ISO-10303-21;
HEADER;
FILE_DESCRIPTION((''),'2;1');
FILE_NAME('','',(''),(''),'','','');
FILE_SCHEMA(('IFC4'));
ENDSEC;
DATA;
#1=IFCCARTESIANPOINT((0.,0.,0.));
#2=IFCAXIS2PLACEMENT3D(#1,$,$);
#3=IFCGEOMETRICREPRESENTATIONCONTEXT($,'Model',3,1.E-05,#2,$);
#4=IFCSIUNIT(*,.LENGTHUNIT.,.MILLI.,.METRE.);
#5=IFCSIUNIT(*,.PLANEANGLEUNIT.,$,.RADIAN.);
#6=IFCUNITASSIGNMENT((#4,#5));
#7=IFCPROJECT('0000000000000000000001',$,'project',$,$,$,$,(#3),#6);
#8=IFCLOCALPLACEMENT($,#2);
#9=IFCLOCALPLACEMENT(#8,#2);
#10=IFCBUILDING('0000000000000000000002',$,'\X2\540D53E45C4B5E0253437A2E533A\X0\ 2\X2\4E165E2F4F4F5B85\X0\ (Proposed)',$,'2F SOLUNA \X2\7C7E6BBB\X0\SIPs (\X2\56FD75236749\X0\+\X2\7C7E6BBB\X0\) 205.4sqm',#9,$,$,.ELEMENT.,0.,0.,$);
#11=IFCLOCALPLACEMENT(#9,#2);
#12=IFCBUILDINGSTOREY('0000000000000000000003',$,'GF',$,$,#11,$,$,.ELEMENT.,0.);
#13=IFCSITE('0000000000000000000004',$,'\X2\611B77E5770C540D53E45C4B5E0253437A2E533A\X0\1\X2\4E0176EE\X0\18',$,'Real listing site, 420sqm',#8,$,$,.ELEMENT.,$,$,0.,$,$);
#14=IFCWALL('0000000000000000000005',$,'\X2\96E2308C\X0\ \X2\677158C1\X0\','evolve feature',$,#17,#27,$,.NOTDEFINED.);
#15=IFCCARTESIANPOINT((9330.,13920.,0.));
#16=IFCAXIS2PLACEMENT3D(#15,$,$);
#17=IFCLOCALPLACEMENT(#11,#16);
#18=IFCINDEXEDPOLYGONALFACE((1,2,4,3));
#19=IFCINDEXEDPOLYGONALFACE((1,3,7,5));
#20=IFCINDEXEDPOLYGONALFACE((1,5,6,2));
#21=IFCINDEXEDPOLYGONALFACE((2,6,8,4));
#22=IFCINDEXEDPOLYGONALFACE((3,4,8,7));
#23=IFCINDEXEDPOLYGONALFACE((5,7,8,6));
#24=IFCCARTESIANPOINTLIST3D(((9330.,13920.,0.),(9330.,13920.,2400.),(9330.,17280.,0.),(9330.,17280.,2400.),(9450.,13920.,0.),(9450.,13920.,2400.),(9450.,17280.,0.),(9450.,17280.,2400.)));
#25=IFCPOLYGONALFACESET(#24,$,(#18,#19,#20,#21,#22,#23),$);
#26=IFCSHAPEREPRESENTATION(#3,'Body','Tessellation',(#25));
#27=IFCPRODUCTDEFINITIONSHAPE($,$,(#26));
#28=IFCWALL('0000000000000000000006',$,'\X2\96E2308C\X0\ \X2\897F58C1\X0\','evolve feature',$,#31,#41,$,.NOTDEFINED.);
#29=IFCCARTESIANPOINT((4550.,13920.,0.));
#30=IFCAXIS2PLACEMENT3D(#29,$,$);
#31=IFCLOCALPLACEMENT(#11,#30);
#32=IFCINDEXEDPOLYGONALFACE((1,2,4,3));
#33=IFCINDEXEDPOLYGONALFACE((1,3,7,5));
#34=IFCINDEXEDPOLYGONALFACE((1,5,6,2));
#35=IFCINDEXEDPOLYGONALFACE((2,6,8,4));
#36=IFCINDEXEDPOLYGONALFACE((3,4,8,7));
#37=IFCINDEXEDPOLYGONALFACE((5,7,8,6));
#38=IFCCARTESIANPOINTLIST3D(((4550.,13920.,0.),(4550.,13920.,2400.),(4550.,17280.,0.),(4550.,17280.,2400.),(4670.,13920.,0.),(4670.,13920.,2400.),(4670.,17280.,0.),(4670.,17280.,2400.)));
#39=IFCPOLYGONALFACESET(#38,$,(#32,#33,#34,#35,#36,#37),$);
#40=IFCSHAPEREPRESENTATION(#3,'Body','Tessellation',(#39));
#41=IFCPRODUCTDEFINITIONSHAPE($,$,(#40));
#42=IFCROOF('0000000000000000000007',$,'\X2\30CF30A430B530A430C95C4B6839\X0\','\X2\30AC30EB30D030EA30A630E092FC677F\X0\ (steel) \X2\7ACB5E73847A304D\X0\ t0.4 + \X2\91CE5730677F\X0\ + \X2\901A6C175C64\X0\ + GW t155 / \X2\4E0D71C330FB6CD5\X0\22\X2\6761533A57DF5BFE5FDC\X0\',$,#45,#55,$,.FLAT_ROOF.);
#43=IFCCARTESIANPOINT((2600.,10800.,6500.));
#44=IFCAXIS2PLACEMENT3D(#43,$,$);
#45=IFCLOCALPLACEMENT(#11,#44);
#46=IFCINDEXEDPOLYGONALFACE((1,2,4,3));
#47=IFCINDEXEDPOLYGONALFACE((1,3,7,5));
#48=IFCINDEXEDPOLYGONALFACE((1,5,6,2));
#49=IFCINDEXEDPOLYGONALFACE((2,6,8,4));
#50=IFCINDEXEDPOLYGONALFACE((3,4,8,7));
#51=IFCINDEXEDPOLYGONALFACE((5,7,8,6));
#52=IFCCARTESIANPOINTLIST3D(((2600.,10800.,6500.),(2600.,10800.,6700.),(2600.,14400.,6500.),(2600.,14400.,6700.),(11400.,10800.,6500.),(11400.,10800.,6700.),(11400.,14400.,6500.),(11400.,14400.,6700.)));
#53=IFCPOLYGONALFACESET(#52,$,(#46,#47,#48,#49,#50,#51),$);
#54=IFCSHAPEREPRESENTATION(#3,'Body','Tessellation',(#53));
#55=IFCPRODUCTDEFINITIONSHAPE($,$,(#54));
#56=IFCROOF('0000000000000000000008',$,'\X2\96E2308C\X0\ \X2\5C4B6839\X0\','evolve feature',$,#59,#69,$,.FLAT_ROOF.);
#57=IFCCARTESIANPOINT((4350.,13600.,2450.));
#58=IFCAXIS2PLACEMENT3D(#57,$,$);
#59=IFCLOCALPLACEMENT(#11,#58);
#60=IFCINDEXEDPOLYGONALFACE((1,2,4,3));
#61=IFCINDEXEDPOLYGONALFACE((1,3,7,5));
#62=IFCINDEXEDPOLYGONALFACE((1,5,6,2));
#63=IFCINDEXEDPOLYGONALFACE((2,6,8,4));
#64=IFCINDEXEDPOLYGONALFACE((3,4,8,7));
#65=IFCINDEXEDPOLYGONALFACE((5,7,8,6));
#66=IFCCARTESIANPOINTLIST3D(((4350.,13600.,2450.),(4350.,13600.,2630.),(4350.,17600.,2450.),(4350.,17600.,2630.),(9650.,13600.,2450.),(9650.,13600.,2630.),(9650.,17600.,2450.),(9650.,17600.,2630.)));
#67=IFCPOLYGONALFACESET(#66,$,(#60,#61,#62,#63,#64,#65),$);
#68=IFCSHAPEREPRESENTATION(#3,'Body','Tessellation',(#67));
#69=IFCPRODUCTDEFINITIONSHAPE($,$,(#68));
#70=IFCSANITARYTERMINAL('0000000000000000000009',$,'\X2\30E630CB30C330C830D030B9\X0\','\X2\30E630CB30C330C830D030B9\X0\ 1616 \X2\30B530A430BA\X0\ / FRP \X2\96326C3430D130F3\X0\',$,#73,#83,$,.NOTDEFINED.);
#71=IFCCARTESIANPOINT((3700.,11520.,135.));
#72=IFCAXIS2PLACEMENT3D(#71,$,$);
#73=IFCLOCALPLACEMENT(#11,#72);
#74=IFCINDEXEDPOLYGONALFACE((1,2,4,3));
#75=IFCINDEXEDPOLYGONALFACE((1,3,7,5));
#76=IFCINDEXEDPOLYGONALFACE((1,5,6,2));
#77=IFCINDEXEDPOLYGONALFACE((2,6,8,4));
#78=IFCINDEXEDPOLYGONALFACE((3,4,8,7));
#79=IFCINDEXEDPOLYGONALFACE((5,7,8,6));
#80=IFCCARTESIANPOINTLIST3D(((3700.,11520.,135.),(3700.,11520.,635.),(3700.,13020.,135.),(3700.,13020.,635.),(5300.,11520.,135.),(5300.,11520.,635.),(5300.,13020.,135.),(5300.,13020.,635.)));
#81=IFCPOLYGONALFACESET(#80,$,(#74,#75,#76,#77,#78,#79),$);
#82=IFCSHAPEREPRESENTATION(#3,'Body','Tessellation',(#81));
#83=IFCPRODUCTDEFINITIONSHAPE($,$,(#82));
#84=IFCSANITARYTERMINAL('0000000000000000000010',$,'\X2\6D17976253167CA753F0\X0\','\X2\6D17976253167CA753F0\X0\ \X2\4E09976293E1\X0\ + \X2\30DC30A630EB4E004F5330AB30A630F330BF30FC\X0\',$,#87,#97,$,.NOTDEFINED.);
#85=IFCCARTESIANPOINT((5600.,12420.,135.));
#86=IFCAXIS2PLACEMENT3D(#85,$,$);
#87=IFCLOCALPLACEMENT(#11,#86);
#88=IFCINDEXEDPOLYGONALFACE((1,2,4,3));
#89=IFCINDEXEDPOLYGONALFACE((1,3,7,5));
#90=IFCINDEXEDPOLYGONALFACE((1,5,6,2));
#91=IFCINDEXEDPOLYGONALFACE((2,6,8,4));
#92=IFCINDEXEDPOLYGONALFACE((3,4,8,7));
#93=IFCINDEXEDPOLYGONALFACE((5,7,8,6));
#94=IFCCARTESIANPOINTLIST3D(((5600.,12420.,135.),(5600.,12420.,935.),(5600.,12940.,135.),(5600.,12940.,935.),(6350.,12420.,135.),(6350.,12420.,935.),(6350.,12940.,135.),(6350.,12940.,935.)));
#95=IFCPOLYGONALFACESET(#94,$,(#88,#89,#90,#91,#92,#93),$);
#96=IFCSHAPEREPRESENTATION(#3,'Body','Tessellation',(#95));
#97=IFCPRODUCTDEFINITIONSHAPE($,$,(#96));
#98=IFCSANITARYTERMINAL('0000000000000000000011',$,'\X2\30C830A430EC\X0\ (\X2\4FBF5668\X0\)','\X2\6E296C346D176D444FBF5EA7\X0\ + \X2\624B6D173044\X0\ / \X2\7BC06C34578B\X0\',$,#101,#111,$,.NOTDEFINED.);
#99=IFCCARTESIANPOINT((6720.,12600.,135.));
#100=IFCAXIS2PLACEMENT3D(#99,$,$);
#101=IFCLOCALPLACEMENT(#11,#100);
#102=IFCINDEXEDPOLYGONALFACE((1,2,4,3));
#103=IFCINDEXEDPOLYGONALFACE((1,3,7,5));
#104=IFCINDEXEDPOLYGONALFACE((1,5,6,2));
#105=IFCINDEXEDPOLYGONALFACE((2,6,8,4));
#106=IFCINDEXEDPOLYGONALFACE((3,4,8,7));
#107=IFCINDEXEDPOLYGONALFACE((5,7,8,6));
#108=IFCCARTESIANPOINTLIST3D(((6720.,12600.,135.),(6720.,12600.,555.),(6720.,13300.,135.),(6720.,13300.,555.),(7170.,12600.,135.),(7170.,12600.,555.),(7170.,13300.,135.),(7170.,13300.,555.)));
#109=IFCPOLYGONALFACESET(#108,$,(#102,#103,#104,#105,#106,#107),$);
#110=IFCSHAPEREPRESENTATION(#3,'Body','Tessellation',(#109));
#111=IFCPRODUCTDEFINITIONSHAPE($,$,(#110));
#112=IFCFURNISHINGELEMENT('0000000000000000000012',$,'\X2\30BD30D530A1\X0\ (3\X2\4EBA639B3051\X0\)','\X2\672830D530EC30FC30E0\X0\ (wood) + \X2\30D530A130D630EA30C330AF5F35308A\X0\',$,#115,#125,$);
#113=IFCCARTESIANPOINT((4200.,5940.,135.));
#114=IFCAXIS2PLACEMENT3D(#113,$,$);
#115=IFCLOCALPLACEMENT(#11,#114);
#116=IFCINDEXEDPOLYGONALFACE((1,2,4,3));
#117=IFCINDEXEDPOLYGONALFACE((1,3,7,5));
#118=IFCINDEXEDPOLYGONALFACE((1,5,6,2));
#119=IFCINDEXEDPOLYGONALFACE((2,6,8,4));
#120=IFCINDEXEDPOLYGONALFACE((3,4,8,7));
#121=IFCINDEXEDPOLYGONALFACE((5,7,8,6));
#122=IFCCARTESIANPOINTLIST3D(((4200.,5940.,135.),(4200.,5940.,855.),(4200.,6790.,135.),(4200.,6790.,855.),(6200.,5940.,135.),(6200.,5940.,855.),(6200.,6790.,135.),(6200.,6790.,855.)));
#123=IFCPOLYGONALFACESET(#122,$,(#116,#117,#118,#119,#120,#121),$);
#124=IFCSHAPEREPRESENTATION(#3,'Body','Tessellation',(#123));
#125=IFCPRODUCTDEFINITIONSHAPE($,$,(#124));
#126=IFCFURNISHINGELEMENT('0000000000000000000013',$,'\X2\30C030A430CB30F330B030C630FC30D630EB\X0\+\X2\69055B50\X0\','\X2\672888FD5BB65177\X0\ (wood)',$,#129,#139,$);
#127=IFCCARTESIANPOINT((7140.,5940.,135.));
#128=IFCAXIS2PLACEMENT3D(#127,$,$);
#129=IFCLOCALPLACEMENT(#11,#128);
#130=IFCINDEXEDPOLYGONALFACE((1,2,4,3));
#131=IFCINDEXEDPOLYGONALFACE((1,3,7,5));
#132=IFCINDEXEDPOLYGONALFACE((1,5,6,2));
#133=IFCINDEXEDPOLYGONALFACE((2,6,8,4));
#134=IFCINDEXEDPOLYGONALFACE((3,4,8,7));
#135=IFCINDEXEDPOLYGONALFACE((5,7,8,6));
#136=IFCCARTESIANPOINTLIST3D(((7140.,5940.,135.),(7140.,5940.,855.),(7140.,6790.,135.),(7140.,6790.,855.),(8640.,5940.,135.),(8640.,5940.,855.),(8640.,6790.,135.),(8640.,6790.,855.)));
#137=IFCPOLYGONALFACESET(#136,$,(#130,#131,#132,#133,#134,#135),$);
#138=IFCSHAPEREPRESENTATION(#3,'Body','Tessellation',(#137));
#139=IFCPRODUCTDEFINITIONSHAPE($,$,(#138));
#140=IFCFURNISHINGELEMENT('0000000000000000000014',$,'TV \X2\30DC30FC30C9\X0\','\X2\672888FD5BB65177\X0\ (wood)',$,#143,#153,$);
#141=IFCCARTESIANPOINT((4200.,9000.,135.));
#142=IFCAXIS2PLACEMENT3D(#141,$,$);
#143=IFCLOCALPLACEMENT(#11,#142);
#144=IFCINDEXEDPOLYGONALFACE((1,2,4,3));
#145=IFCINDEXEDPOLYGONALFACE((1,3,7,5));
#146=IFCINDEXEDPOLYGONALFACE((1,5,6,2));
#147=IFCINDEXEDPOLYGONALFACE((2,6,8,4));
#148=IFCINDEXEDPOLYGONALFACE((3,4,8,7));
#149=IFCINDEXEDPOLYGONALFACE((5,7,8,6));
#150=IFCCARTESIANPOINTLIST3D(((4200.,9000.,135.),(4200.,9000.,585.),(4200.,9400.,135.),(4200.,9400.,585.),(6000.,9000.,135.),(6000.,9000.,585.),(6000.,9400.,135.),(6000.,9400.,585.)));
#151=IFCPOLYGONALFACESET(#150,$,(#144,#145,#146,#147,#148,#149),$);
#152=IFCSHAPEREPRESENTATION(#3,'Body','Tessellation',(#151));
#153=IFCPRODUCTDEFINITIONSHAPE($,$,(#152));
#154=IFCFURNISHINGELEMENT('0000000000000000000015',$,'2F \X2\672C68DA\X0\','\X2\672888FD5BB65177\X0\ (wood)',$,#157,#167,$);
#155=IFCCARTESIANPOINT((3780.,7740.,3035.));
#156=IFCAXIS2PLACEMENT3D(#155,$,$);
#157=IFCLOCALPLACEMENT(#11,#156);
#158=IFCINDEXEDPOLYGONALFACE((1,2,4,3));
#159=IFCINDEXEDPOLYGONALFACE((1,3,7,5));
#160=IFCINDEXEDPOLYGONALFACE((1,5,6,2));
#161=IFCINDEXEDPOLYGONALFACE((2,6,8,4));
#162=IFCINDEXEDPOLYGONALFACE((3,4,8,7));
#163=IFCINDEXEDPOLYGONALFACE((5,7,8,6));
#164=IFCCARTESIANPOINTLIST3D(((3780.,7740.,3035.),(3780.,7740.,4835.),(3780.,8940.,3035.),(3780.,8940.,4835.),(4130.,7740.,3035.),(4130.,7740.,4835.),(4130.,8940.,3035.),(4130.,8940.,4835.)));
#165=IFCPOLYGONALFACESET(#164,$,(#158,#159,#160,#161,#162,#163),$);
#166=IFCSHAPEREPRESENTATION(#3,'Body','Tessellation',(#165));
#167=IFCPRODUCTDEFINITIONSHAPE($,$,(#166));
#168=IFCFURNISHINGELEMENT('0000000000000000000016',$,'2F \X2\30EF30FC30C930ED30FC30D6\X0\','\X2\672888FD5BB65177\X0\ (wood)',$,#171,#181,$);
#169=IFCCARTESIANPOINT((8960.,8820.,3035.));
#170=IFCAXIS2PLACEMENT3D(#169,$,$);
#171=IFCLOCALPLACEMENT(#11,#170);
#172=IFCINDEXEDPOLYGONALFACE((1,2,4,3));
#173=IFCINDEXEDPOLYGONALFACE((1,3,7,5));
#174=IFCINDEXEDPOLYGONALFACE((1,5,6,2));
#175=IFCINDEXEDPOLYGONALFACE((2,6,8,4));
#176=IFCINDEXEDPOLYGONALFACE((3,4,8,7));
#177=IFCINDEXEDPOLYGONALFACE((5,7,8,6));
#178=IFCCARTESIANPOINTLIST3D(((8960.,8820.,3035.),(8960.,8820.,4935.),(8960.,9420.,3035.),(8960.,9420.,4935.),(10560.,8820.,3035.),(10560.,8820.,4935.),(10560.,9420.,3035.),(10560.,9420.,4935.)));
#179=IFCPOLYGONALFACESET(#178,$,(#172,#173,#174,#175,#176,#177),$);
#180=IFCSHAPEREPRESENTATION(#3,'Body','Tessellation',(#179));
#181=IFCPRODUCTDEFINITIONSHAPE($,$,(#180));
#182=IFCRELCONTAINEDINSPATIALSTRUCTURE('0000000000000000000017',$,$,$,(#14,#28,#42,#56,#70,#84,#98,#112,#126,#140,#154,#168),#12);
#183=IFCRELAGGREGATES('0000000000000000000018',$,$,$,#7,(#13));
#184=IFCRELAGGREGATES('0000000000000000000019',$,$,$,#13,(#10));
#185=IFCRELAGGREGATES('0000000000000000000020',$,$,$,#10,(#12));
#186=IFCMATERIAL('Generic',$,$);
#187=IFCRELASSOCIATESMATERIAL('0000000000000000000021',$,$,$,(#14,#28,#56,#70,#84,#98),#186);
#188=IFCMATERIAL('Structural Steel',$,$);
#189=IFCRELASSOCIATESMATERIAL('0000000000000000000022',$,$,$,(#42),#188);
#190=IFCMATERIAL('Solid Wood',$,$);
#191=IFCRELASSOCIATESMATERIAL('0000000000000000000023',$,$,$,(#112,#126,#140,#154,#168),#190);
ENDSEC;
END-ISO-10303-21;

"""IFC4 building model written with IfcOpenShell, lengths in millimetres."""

from ifc_helpers import new_model, si_unit, frame, frame_2d, origin, place, context, project, spatial, rectangle, extrude, material, element, save


model = new_model("IFC4")

# Units and contexts
model_context = context("Model", 3, precision=1e-05, world=origin())
ifc_project = project(units=[si_unit("LENGTHUNIT", "METRE", prefix="MILLI"), si_unit("PLANEANGLEUNIT", "RADIAN")], contexts=[model_context])

# Site, building, storey
site_placement = place(None, origin())
site = spatial("IfcSite", under=ifc_project, at=site_placement, Name="愛知県名古屋市千種区1丁目18", ObjectType="Real listing site, 420sqm", CompositionType="ELEMENT", RefElevation=0.0)
building_placement = place(site_placement, origin())
building = spatial("IfcBuilding", under=site, at=building_placement, Name="名古屋市千種区 2世帯住宅 (Proposed)", ObjectType="2F SOLUNA 籾殻SIPs (国産杉+籾殻) 205.4sqm", CompositionType="ELEMENT", ElevationOfRefHeight=0.0, ElevationOfTerrain=0.0)
storey_placement = place(building_placement, origin())
storey = spatial("IfcBuildingStorey", under=building, at=storey_placement, Name="GF", CompositionType="ELEMENT", Elevation=0.0)

# Shared definitions
ifc_material_1 = material(Name="Generic")

# Shared definitions
ifc_material_2 = material(Name="Solid Wood")

# Walls
wall_1_placement = place(storey_placement, frame((9330.0, 13920.0, 0.0)))
element("IfcWall", 1, at=wall_1_placement, inside=storey, material=ifc_material_1, Name="離れ 東壁", Description="evolve feature", PredefinedType="NOTDEFINED", context=model_context, shape_type="SweptSolid", body=[
    extrude(rectangle(XDim=120.0, YDim=3360.0, at=frame_2d((60.0, 1680.0))), frame((9330.0, 13920.0, 0.0)), (0.0, 0.0, 1.0), 2400.0),
])
wall_2_placement = place(storey_placement, frame((4550.0, 13920.0, 0.0)))
element("IfcWall", 2, at=wall_2_placement, inside=storey, material=ifc_material_1, Name="離れ 西壁", Description="evolve feature", PredefinedType="NOTDEFINED", context=model_context, shape_type="SweptSolid", body=[
    extrude(rectangle(XDim=120.0, YDim=3360.0, at=frame_2d((60.0, 1680.0))), frame((4550.0, 13920.0, 0.0)), (0.0, 0.0, 1.0), 2400.0),
])

# Roofs
ifc_material_3 = material(Name="Structural Steel")
roof_1_placement = place(storey_placement, frame((2600.0, 10800.0, 6500.0)))
element("IfcRoof", 3, at=roof_1_placement, inside=storey, material=ifc_material_3, Name="ハイサイド屋根", Description="ガルバリウム鋼板 (steel) 立平葺き t0.4 + 野地板 + 通気層 + GW t155 / 不燃・法22条区域対応", PredefinedType="FLAT_ROOF", context=model_context, shape_type="SweptSolid", body=[
    extrude(rectangle(XDim=8800.0, YDim=3600.0, at=frame_2d((4400.0, 1800.0))), frame((2600.0, 10800.0, 6500.0)), (0.0, 0.0, 1.0), 200.0),
])
roof_2_placement = place(storey_placement, frame((4350.0, 13600.0, 2450.0)))
element("IfcRoof", 4, at=roof_2_placement, inside=storey, material=ifc_material_1, Name="離れ 屋根", Description="evolve feature", PredefinedType="FLAT_ROOF", context=model_context, shape_type="SweptSolid", body=[
    extrude(rectangle(XDim=5300.0, YDim=4000.0, at=frame_2d((2650.0, 2000.0))), frame((4350.0, 13600.0, 2450.0)), (0.0, 0.0, 1.0), 180.0),
])

# Sanitary terminals
sanitary_terminal_1_placement = place(storey_placement, frame((3700.0, 11520.0, 135.0)))
element("IfcSanitaryTerminal", 5, at=sanitary_terminal_1_placement, inside=storey, material=ifc_material_1, Name="ユニットバス", Description="ユニットバス 1616 サイズ / FRP 防水パン", PredefinedType="NOTDEFINED", context=model_context, shape_type="SweptSolid", body=[
    extrude(rectangle(XDim=1600.0, YDim=1500.0, at=frame_2d((800.0, 750.0))), frame((3700.0, 11520.0, 135.0)), (0.0, 0.0, 1.0), 500.0),
])
sanitary_terminal_2_placement = place(storey_placement, frame((5600.0, 12420.0, 135.0)))
element("IfcSanitaryTerminal", 6, at=sanitary_terminal_2_placement, inside=storey, material=ifc_material_1, Name="洗面化粧台", Description="洗面化粧台 三面鏡 + ボウル一体カウンター", PredefinedType="NOTDEFINED", context=model_context, shape_type="SweptSolid", body=[
    extrude(rectangle(XDim=750.0, YDim=520.0, at=frame_2d((375.0, 260.0))), frame((5600.0, 12420.0, 135.0)), (0.0, 0.0, 1.0), 800.0),
])
sanitary_terminal_3_placement = place(storey_placement, frame((6720.0, 12600.0, 135.0)))
element("IfcSanitaryTerminal", 7, at=sanitary_terminal_3_placement, inside=storey, material=ifc_material_1, Name="トイレ (便器)", Description="温水洗浄便座 + 手洗い / 節水型", PredefinedType="NOTDEFINED", context=model_context, shape_type="SweptSolid", body=[
    extrude(rectangle(XDim=450.0, YDim=700.0, at=frame_2d((225.0, 350.0))), frame((6720.0, 12600.0, 135.0)), (0.0, 0.0, 1.0), 420.0),
])

# Furnishing elements
furnishing_1_placement = place(storey_placement, frame((4200.0, 5940.0, 135.0)))
element("IfcFurnishingElement", 8, at=furnishing_1_placement, inside=storey, material=ifc_material_2, Name="ソファ (3人掛け)", Description="木フレーム (wood) + ファブリック張り", context=model_context, shape_type="SweptSolid", body=[
    extrude(rectangle(XDim=2000.0, YDim=850.0, at=frame_2d((1000.0, 425.0))), frame((4200.0, 5940.0, 135.0)), (0.0, 0.0, 1.0), 720.0),
])
furnishing_2_placement = place(storey_placement, frame((7140.0, 5940.0, 135.0)))
element("IfcFurnishingElement", 9, at=furnishing_2_placement, inside=storey, material=ifc_material_2, Name="ダイニングテーブル+椅子", Description="木製家具 (wood)", context=model_context, shape_type="SweptSolid", body=[
    extrude(rectangle(XDim=1500.0, YDim=850.0, at=frame_2d((750.0, 425.0))), frame((7140.0, 5940.0, 135.0)), (0.0, 0.0, 1.0), 720.0),
])
furnishing_3_placement = place(storey_placement, frame((4200.0, 9000.0, 135.0)))
element("IfcFurnishingElement", 10, at=furnishing_3_placement, inside=storey, material=ifc_material_2, Name="TV ボード", Description="木製家具 (wood)", context=model_context, shape_type="SweptSolid", body=[
    extrude(rectangle(XDim=1800.0, YDim=400.0, at=frame_2d((900.0, 200.0))), frame((4200.0, 9000.0, 135.0)), (0.0, 0.0, 1.0), 450.0),
])
furnishing_4_placement = place(storey_placement, frame((3780.0, 7740.0, 3035.0)))
element("IfcFurnishingElement", 11, at=furnishing_4_placement, inside=storey, material=ifc_material_2, Name="2F 本棚", Description="木製家具 (wood)", context=model_context, shape_type="SweptSolid", body=[
    extrude(rectangle(XDim=350.0, YDim=1200.0, at=frame_2d((175.0, 600.0))), frame((3780.0, 7740.0, 3035.0)), (0.0, 0.0, 1.0), 1800.0),
])
furnishing_5_placement = place(storey_placement, frame((8960.0, 8820.0, 3035.0)))
element("IfcFurnishingElement", 12, at=furnishing_5_placement, inside=storey, material=ifc_material_2, Name="2F ワードローブ", Description="木製家具 (wood)", context=model_context, shape_type="SweptSolid", body=[
    extrude(rectangle(XDim=1600.0, YDim=600.0, at=frame_2d((800.0, 300.0))), frame((8960.0, 8820.0, 3035.0)), (0.0, 0.0, 1.0), 1900.0),
])

save(model, "model.ifc")
